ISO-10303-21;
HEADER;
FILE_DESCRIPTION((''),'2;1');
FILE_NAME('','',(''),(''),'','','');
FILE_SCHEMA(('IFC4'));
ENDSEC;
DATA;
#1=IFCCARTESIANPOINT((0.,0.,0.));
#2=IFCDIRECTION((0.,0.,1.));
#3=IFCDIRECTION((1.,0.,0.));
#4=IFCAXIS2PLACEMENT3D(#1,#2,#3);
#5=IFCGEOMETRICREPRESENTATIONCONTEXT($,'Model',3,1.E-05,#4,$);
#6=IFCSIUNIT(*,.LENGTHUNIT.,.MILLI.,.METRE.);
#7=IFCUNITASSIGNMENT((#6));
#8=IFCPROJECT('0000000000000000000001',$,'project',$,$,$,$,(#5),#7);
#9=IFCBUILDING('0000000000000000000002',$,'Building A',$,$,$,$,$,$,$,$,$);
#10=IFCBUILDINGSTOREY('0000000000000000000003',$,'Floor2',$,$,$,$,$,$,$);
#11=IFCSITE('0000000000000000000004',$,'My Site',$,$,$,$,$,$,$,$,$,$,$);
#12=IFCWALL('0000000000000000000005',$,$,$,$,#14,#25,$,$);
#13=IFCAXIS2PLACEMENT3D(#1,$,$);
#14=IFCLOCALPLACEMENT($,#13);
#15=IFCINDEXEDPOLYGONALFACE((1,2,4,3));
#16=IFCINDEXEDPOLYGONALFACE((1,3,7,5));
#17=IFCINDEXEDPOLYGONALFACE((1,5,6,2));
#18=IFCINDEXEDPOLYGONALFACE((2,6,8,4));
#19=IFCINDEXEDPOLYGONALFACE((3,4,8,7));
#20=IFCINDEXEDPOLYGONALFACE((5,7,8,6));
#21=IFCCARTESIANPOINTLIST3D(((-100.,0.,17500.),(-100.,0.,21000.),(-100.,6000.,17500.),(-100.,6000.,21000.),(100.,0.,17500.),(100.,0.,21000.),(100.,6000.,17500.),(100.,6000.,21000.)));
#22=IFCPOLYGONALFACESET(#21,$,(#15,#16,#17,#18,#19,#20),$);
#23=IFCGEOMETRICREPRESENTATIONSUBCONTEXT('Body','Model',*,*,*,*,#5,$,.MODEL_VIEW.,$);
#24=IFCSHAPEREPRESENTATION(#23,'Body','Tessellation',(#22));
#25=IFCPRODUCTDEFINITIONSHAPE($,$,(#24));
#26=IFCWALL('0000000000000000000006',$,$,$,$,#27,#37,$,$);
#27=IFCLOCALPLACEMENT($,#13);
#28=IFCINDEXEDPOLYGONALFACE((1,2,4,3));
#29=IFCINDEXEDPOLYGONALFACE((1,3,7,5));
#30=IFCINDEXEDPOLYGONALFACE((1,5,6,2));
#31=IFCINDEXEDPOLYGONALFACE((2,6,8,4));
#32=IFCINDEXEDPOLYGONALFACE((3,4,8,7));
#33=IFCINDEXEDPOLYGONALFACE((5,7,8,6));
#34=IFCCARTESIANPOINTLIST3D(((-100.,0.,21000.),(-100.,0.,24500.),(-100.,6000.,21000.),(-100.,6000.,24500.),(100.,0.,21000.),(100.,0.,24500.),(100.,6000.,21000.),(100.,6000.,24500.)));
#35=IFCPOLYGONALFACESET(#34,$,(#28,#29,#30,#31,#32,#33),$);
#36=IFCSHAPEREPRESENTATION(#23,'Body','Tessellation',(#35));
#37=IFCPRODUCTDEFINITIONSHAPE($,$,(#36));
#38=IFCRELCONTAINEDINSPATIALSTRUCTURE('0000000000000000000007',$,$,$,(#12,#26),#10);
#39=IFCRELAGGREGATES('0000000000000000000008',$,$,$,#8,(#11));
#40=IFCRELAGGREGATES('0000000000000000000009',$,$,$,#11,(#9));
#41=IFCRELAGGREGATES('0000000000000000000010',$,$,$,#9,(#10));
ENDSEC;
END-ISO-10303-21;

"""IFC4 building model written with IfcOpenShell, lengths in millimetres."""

from ifc_helpers import new_model, si_unit, frame, origin_with_axes, place, context, subcontext, project, spatial, indexed_curve, outline, extrude, element, save


model = new_model("IFC4")

# Units and contexts
model_context = context("Model", 3, precision=1e-05, world=origin_with_axes())
body_context = subcontext(model_context, "Body", "Model", "MODEL_VIEW")
ifc_project = project(units=[si_unit("LENGTHUNIT", "METRE", prefix="MILLI")], contexts=[model_context])

# Site, building, storey
site = spatial("IfcSite", under=ifc_project, Name="My Site")
building = spatial("IfcBuilding", under=site, Name="Building A")
storey = spatial("IfcBuildingStorey", under=building, Name="Floor2")

# Walls
for number, where, z_axis, x_axis in (
    (1, (-100.0, 6000.0, 17500.0), (0.0, 0.0, 1.0), (0.0, -1.0, 0.0)),
    (2, (-100.0, 6000.0, 21000.0), (0.0, 0.0, 1.0), (0.0, -1.0, 0.0)),
):
    element("IfcWall", number, at=place(None, frame(where, z_axis=z_axis, x_axis=x_axis)), inside=storey, context=body_context, shape_type="SweptSolid", body=[
        extrude(outline(indexed_curve([(0.0, 0.0), (0.0, 200.0), (6000.0, 200.0), (6000.0, 0.0), (0.0, 0.0)], self_intersect=False)), origin_with_axes(), (0.0, 0.0, 1.0), 3500.0),
    ])

save(model, "model.ifc")
